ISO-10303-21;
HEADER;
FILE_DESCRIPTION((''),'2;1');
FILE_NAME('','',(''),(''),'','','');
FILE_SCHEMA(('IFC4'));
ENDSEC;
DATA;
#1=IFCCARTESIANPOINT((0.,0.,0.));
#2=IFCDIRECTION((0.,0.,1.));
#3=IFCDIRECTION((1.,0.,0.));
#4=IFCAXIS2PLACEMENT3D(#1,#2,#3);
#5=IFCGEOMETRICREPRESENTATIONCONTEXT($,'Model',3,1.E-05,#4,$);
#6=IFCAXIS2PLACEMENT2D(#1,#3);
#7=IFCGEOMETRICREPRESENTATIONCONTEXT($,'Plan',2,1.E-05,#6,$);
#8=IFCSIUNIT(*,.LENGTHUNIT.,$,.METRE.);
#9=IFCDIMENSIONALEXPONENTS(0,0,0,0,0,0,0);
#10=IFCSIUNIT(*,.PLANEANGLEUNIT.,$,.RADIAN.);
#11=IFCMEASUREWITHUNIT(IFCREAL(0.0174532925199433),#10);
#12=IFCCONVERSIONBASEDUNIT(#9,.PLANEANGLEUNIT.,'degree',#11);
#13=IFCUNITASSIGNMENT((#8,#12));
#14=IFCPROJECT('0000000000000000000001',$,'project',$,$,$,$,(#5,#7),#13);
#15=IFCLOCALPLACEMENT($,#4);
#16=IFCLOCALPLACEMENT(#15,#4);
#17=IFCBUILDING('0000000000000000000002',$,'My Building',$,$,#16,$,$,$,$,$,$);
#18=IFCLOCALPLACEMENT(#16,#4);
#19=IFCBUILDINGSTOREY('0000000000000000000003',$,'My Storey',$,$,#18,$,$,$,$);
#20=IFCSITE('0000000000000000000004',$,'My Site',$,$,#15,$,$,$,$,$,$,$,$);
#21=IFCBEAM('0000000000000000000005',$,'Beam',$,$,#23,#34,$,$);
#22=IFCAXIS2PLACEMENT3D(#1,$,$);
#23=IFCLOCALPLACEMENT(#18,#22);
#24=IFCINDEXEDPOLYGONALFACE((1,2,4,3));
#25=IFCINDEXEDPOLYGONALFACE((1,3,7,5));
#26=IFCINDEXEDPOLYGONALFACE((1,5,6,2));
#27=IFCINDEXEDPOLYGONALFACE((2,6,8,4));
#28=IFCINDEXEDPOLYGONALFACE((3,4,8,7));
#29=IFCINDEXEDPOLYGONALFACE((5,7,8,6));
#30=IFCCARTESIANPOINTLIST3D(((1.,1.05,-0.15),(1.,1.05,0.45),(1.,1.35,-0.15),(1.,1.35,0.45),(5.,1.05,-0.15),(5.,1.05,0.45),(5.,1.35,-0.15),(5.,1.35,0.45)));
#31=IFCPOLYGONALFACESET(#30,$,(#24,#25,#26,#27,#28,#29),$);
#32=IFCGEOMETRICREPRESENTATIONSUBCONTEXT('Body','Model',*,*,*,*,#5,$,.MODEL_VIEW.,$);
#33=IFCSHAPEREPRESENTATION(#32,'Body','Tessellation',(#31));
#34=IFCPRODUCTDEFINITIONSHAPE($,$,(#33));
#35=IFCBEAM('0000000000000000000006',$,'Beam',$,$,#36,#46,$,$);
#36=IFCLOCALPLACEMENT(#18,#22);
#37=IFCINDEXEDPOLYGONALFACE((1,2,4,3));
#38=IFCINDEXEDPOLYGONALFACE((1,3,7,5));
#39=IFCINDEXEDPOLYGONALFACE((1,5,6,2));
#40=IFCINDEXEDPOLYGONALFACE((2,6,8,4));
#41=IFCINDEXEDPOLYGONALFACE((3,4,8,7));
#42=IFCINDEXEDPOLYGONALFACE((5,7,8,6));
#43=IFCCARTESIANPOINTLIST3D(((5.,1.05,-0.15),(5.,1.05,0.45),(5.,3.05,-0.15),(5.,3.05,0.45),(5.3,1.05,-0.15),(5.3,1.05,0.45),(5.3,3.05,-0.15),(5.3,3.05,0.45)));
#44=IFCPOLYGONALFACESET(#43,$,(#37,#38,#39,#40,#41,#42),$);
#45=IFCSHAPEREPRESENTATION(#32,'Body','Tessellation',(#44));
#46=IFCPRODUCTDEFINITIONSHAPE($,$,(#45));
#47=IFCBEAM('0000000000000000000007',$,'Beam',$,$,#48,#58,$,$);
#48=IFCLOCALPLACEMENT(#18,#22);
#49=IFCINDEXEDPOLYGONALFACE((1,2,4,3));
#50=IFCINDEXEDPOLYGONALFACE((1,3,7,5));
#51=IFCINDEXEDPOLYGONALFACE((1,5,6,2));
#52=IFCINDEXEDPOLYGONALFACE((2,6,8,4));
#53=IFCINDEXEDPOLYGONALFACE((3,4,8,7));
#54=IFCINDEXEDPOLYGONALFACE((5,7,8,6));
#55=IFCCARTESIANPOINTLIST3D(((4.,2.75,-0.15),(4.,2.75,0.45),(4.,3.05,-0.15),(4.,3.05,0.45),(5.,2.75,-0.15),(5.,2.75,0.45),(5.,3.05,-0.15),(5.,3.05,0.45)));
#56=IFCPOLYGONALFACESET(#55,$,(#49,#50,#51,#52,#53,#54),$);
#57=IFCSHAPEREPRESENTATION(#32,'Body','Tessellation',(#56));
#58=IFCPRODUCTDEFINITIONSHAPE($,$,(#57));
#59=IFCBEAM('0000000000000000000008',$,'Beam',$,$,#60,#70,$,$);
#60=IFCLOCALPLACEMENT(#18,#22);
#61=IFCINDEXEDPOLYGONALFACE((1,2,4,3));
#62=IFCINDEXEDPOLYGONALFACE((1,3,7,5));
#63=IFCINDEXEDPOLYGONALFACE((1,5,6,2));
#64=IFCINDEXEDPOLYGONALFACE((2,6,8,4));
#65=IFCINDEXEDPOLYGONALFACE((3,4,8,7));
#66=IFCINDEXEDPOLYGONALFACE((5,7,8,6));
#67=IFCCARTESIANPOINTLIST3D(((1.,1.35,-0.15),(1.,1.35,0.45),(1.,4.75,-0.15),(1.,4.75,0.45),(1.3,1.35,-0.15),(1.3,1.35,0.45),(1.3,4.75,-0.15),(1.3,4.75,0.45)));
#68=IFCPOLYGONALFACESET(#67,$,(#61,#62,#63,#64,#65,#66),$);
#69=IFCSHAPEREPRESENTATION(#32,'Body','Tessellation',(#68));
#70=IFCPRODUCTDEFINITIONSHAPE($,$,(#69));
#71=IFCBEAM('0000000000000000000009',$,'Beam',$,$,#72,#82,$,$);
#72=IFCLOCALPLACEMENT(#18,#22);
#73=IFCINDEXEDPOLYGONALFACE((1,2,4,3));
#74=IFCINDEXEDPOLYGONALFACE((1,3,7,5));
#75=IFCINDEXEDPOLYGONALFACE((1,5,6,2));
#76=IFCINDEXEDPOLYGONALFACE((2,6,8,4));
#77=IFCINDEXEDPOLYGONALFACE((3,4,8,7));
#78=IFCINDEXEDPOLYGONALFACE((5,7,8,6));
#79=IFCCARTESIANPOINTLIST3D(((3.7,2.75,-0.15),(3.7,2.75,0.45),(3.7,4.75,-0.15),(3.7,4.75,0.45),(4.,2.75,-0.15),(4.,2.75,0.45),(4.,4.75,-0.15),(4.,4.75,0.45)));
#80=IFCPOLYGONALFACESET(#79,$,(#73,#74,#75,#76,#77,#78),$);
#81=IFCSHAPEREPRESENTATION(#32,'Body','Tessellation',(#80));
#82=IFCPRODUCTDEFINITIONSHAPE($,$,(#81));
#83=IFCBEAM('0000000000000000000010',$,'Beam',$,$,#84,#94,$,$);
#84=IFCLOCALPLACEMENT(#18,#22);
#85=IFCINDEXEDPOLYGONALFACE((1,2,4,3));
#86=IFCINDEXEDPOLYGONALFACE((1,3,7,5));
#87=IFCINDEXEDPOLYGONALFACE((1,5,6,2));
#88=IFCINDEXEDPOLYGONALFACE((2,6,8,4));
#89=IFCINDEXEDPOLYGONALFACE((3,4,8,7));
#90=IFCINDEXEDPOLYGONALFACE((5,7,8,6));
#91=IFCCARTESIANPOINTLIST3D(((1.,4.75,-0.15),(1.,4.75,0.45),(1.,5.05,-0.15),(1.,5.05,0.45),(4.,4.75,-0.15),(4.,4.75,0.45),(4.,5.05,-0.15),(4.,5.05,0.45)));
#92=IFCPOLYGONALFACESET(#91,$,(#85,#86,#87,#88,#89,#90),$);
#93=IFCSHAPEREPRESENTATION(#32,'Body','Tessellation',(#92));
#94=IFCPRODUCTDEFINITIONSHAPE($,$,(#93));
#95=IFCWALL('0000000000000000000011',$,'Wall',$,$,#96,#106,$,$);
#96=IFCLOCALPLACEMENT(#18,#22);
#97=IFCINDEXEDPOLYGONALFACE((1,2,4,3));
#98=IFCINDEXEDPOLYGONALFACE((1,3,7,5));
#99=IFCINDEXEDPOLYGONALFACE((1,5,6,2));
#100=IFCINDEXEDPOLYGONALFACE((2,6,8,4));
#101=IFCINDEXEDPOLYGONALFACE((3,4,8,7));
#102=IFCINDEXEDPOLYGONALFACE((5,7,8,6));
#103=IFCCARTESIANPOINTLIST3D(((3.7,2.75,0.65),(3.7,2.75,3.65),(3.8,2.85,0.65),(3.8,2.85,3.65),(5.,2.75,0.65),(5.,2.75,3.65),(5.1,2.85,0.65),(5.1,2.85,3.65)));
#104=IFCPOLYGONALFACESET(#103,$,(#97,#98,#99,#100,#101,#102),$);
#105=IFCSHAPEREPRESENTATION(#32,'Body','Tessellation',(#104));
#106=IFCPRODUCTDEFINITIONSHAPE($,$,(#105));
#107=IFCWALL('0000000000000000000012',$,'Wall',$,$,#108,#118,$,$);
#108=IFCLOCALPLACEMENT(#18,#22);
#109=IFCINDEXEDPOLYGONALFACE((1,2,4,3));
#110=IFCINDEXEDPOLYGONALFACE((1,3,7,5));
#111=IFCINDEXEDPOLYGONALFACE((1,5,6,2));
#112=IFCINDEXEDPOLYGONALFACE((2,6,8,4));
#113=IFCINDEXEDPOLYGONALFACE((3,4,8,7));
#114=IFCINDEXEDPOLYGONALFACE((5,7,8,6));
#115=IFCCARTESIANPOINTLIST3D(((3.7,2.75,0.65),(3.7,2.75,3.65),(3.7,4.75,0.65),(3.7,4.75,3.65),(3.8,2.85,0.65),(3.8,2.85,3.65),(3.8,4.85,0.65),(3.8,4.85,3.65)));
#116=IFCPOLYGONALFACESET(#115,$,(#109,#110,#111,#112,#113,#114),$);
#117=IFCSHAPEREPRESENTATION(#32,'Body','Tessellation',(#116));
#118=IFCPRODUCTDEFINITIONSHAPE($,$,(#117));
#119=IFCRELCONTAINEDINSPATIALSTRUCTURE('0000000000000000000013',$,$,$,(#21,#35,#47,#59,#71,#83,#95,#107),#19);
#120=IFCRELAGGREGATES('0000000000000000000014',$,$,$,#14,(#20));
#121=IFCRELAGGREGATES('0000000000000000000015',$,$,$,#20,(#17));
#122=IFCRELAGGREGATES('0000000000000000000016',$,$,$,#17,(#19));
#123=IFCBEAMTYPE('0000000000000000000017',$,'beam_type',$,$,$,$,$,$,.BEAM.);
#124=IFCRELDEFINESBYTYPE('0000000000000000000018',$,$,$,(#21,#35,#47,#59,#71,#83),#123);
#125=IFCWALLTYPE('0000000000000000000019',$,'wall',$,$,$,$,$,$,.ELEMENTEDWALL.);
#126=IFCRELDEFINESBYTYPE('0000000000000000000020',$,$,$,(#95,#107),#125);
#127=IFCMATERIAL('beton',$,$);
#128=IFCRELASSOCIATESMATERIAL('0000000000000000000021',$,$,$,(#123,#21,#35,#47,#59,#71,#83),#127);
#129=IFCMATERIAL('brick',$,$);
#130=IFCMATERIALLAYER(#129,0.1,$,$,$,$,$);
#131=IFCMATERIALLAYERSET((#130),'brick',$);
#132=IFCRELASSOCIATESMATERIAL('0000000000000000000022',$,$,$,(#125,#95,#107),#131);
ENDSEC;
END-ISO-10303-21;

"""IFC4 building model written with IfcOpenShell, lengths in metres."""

from ifc_helpers import new_model, entity, si_unit, converted_unit, frame, frame_2d, origin_with_axes, place, context, subcontext, project, spatial, polyline, rectangle, outline, extrude, material, layer, layer_set, layer_usage, material_profile, profile_set, profile_usage, type_object, element, save


model = new_model("IFC4")

# Units and contexts
model_context = context("Model", 3, precision=1e-05, world=origin_with_axes())
plan_context = context("Plan", 2, precision=1e-05, world=frame_2d((0.0, 0.0, 0.0), x_axis=(1.0, 0.0, 0.0)))
body_context = subcontext(model_context, "Body", "Model", "MODEL_VIEW")
ifc_project = project(units=[si_unit("LENGTHUNIT", "METRE"), converted_unit("PLANEANGLEUNIT", "degree", entity("IfcReal", 0.0174532925199433), si_unit("PLANEANGLEUNIT", "RADIAN"), dimensions=[0, 0, 0, 0, 0, 0, 0])], contexts=[model_context, plan_context])

# Site, building, storey
site_placement = place(None, origin_with_axes())
site = spatial("IfcSite", under=ifc_project, at=site_placement, Name="My Site")
building_placement = place(site_placement, origin_with_axes())
building = spatial("IfcBuilding", under=site, at=building_placement, Name="My Building")
storey_placement = place(building_placement, origin_with_axes())
storey = spatial("IfcBuildingStorey", under=building, at=storey_placement, Name="My Storey")

# Beams
ifc_material_1 = material(Name="beton")
ifc_material_profile = material_profile(ifc_material_1, rectangle(XDim=0.3, YDim=0.6))
ifc_profile_set = profile_set([ifc_material_profile])
ifc_profile_usage_1 = profile_usage(ifc_profile_set)
beam_type = type_object("IfcBeamType", Name="beam_type", PredefinedType="BEAM", material=ifc_profile_set)
beam_1_placement = place(storey_placement, frame((1.0, 1.2, 0.15), z_axis=(1.0, 0.0, 0.0), x_axis=(0.0, 1.0, 0.0)))
element("IfcBeam", 1, at=beam_1_placement, inside=storey, type_object=beam_type, material=ifc_profile_usage_1, Name="Beam", context=body_context, shape_type="SweptSolid", body=[
    extrude(rectangle(XDim=0.3, YDim=0.6), None, (0.0, 0.0, 1.0), 4.0),
])
ifc_profile_usage_2 = profile_usage(ifc_profile_set)
beam_2_placement = place(storey_placement, frame((5.15, 3.05, 0.15), z_axis=(0.0, -1.0, 0.0), x_axis=(1.0, 0.0, 0.0)))
element("IfcBeam", 2, at=beam_2_placement, inside=storey, type_object=beam_type, material=ifc_profile_usage_2, Name="Beam", context=body_context, shape_type="SweptSolid", body=[
    extrude(rectangle(XDim=0.3, YDim=0.6), None, (0.0, 0.0, 1.0), 2.0),
])
ifc_profile_usage_3 = profile_usage(ifc_profile_set)
beam_3_placement = place(storey_placement, frame((4.0, 2.9, 0.15), z_axis=(1.0, 0.0, 0.0), x_axis=(0.0, 1.0, 0.0)))
element("IfcBeam", 3, at=beam_3_placement, inside=storey, type_object=beam_type, material=ifc_profile_usage_3, Name="Beam", context=body_context, shape_type="SweptSolid", body=[
    extrude(rectangle(XDim=0.3, YDim=0.6), None, (0.0, 0.0, 1.0), 1.0),
])
ifc_profile_usage_4 = profile_usage(ifc_profile_set)
beam_4_placement = place(storey_placement, frame((1.15, 1.35, 0.15), z_axis=(0.0, 1.0, 0.0), x_axis=(-1.0, 0.0, 0.0)))
element("IfcBeam", 4, at=beam_4_placement, inside=storey, type_object=beam_type, material=ifc_profile_usage_4, Name="Beam", context=body_context, shape_type="SweptSolid", body=[
    extrude(rectangle(XDim=0.3, YDim=0.6), None, (0.0, 0.0, 1.0), 3.4),
])
ifc_profile_usage_5 = profile_usage(ifc_profile_set)
beam_5_placement = place(storey_placement, frame((3.85, 2.75, 0.15), z_axis=(0.0, 1.0, 0.0), x_axis=(-1.0, 0.0, 0.0)))
element("IfcBeam", 5, at=beam_5_placement, inside=storey, type_object=beam_type, material=ifc_profile_usage_5, Name="Beam", context=body_context, shape_type="SweptSolid", body=[
    extrude(rectangle(XDim=0.3, YDim=0.6), None, (0.0, 0.0, 1.0), 2.0),
])
ifc_profile_usage_6 = profile_usage(ifc_profile_set)
beam_6_placement = place(storey_placement, frame((1.0, 4.9, 0.15), z_axis=(1.0, 0.0, 0.0), x_axis=(0.0, 1.0, 0.0)))
element("IfcBeam", 6, at=beam_6_placement, inside=storey, type_object=beam_type, material=ifc_profile_usage_6, Name="Beam", context=body_context, shape_type="SweptSolid", body=[
    extrude(rectangle(XDim=0.3, YDim=0.6), None, (0.0, 0.0, 1.0), 3.0),
])

# Walls
ifc_material_2 = material(Name="brick")
ifc_layer = layer(ifc_material_2, 0.1)
ifc_layer_set = layer_set([ifc_layer], Name="brick")
wall_type = type_object("IfcWallType", Name="wall", PredefinedType="ELEMENTEDWALL", material=ifc_layer_set)
ifc_layer_usage_1 = layer_usage(ifc_layer_set, "AXIS2", "POSITIVE", 0.0)
wall_1_placement = place(storey_placement, frame((5.1, 2.85, 0.65), z_axis=(0.0, 0.0, 1.0), x_axis=(-1.0, 0.0, 0.0)))
element("IfcWall", 7, at=wall_1_placement, inside=storey, type_object=wall_type, material=ifc_layer_usage_1, Name="Wall", context=body_context, shape_type="SweptSolid", body=[
    extrude(outline(polyline([(-0.5303, -0.4596), (-0.3889, -0.4596), (0.5303, 0.4596), (0.3889, 0.4596), (-0.5303, -0.4596)])), frame((0.7, 0.05, 0.0), z_axis=(0.0, 0.0, -1.0), x_axis=(-0.707107, -0.707107, 0.0)), (0.0, 0.0, -1.0), 3.0),
])
ifc_layer_usage_2 = layer_usage(ifc_layer_set, "AXIS2", "POSITIVE", 0.0)
wall_2_placement = place(storey_placement, frame((3.8, 2.75, 0.65), z_axis=(0.0, 0.0, 1.0), x_axis=(0.0, 1.0, 0.0)))
element("IfcWall", 8, at=wall_2_placement, inside=storey, type_object=wall_type, material=ifc_layer_usage_2, Name="Wall", context=body_context, shape_type="SweptSolid", body=[
    extrude(outline(polyline([(0.6364, -0.7071), (0.7778, -0.7071), (-0.6364, 0.7071), (-0.7778, 0.7071), (0.6364, -0.7071)])), frame((1.05, 0.05, 0.0), z_axis=(0.0, 0.0, -1.0), x_axis=(-0.707107, 0.707107, 0.0)), (0.0, 0.0, -1.0), 3.0),
])

save(model, "model.ifc")
